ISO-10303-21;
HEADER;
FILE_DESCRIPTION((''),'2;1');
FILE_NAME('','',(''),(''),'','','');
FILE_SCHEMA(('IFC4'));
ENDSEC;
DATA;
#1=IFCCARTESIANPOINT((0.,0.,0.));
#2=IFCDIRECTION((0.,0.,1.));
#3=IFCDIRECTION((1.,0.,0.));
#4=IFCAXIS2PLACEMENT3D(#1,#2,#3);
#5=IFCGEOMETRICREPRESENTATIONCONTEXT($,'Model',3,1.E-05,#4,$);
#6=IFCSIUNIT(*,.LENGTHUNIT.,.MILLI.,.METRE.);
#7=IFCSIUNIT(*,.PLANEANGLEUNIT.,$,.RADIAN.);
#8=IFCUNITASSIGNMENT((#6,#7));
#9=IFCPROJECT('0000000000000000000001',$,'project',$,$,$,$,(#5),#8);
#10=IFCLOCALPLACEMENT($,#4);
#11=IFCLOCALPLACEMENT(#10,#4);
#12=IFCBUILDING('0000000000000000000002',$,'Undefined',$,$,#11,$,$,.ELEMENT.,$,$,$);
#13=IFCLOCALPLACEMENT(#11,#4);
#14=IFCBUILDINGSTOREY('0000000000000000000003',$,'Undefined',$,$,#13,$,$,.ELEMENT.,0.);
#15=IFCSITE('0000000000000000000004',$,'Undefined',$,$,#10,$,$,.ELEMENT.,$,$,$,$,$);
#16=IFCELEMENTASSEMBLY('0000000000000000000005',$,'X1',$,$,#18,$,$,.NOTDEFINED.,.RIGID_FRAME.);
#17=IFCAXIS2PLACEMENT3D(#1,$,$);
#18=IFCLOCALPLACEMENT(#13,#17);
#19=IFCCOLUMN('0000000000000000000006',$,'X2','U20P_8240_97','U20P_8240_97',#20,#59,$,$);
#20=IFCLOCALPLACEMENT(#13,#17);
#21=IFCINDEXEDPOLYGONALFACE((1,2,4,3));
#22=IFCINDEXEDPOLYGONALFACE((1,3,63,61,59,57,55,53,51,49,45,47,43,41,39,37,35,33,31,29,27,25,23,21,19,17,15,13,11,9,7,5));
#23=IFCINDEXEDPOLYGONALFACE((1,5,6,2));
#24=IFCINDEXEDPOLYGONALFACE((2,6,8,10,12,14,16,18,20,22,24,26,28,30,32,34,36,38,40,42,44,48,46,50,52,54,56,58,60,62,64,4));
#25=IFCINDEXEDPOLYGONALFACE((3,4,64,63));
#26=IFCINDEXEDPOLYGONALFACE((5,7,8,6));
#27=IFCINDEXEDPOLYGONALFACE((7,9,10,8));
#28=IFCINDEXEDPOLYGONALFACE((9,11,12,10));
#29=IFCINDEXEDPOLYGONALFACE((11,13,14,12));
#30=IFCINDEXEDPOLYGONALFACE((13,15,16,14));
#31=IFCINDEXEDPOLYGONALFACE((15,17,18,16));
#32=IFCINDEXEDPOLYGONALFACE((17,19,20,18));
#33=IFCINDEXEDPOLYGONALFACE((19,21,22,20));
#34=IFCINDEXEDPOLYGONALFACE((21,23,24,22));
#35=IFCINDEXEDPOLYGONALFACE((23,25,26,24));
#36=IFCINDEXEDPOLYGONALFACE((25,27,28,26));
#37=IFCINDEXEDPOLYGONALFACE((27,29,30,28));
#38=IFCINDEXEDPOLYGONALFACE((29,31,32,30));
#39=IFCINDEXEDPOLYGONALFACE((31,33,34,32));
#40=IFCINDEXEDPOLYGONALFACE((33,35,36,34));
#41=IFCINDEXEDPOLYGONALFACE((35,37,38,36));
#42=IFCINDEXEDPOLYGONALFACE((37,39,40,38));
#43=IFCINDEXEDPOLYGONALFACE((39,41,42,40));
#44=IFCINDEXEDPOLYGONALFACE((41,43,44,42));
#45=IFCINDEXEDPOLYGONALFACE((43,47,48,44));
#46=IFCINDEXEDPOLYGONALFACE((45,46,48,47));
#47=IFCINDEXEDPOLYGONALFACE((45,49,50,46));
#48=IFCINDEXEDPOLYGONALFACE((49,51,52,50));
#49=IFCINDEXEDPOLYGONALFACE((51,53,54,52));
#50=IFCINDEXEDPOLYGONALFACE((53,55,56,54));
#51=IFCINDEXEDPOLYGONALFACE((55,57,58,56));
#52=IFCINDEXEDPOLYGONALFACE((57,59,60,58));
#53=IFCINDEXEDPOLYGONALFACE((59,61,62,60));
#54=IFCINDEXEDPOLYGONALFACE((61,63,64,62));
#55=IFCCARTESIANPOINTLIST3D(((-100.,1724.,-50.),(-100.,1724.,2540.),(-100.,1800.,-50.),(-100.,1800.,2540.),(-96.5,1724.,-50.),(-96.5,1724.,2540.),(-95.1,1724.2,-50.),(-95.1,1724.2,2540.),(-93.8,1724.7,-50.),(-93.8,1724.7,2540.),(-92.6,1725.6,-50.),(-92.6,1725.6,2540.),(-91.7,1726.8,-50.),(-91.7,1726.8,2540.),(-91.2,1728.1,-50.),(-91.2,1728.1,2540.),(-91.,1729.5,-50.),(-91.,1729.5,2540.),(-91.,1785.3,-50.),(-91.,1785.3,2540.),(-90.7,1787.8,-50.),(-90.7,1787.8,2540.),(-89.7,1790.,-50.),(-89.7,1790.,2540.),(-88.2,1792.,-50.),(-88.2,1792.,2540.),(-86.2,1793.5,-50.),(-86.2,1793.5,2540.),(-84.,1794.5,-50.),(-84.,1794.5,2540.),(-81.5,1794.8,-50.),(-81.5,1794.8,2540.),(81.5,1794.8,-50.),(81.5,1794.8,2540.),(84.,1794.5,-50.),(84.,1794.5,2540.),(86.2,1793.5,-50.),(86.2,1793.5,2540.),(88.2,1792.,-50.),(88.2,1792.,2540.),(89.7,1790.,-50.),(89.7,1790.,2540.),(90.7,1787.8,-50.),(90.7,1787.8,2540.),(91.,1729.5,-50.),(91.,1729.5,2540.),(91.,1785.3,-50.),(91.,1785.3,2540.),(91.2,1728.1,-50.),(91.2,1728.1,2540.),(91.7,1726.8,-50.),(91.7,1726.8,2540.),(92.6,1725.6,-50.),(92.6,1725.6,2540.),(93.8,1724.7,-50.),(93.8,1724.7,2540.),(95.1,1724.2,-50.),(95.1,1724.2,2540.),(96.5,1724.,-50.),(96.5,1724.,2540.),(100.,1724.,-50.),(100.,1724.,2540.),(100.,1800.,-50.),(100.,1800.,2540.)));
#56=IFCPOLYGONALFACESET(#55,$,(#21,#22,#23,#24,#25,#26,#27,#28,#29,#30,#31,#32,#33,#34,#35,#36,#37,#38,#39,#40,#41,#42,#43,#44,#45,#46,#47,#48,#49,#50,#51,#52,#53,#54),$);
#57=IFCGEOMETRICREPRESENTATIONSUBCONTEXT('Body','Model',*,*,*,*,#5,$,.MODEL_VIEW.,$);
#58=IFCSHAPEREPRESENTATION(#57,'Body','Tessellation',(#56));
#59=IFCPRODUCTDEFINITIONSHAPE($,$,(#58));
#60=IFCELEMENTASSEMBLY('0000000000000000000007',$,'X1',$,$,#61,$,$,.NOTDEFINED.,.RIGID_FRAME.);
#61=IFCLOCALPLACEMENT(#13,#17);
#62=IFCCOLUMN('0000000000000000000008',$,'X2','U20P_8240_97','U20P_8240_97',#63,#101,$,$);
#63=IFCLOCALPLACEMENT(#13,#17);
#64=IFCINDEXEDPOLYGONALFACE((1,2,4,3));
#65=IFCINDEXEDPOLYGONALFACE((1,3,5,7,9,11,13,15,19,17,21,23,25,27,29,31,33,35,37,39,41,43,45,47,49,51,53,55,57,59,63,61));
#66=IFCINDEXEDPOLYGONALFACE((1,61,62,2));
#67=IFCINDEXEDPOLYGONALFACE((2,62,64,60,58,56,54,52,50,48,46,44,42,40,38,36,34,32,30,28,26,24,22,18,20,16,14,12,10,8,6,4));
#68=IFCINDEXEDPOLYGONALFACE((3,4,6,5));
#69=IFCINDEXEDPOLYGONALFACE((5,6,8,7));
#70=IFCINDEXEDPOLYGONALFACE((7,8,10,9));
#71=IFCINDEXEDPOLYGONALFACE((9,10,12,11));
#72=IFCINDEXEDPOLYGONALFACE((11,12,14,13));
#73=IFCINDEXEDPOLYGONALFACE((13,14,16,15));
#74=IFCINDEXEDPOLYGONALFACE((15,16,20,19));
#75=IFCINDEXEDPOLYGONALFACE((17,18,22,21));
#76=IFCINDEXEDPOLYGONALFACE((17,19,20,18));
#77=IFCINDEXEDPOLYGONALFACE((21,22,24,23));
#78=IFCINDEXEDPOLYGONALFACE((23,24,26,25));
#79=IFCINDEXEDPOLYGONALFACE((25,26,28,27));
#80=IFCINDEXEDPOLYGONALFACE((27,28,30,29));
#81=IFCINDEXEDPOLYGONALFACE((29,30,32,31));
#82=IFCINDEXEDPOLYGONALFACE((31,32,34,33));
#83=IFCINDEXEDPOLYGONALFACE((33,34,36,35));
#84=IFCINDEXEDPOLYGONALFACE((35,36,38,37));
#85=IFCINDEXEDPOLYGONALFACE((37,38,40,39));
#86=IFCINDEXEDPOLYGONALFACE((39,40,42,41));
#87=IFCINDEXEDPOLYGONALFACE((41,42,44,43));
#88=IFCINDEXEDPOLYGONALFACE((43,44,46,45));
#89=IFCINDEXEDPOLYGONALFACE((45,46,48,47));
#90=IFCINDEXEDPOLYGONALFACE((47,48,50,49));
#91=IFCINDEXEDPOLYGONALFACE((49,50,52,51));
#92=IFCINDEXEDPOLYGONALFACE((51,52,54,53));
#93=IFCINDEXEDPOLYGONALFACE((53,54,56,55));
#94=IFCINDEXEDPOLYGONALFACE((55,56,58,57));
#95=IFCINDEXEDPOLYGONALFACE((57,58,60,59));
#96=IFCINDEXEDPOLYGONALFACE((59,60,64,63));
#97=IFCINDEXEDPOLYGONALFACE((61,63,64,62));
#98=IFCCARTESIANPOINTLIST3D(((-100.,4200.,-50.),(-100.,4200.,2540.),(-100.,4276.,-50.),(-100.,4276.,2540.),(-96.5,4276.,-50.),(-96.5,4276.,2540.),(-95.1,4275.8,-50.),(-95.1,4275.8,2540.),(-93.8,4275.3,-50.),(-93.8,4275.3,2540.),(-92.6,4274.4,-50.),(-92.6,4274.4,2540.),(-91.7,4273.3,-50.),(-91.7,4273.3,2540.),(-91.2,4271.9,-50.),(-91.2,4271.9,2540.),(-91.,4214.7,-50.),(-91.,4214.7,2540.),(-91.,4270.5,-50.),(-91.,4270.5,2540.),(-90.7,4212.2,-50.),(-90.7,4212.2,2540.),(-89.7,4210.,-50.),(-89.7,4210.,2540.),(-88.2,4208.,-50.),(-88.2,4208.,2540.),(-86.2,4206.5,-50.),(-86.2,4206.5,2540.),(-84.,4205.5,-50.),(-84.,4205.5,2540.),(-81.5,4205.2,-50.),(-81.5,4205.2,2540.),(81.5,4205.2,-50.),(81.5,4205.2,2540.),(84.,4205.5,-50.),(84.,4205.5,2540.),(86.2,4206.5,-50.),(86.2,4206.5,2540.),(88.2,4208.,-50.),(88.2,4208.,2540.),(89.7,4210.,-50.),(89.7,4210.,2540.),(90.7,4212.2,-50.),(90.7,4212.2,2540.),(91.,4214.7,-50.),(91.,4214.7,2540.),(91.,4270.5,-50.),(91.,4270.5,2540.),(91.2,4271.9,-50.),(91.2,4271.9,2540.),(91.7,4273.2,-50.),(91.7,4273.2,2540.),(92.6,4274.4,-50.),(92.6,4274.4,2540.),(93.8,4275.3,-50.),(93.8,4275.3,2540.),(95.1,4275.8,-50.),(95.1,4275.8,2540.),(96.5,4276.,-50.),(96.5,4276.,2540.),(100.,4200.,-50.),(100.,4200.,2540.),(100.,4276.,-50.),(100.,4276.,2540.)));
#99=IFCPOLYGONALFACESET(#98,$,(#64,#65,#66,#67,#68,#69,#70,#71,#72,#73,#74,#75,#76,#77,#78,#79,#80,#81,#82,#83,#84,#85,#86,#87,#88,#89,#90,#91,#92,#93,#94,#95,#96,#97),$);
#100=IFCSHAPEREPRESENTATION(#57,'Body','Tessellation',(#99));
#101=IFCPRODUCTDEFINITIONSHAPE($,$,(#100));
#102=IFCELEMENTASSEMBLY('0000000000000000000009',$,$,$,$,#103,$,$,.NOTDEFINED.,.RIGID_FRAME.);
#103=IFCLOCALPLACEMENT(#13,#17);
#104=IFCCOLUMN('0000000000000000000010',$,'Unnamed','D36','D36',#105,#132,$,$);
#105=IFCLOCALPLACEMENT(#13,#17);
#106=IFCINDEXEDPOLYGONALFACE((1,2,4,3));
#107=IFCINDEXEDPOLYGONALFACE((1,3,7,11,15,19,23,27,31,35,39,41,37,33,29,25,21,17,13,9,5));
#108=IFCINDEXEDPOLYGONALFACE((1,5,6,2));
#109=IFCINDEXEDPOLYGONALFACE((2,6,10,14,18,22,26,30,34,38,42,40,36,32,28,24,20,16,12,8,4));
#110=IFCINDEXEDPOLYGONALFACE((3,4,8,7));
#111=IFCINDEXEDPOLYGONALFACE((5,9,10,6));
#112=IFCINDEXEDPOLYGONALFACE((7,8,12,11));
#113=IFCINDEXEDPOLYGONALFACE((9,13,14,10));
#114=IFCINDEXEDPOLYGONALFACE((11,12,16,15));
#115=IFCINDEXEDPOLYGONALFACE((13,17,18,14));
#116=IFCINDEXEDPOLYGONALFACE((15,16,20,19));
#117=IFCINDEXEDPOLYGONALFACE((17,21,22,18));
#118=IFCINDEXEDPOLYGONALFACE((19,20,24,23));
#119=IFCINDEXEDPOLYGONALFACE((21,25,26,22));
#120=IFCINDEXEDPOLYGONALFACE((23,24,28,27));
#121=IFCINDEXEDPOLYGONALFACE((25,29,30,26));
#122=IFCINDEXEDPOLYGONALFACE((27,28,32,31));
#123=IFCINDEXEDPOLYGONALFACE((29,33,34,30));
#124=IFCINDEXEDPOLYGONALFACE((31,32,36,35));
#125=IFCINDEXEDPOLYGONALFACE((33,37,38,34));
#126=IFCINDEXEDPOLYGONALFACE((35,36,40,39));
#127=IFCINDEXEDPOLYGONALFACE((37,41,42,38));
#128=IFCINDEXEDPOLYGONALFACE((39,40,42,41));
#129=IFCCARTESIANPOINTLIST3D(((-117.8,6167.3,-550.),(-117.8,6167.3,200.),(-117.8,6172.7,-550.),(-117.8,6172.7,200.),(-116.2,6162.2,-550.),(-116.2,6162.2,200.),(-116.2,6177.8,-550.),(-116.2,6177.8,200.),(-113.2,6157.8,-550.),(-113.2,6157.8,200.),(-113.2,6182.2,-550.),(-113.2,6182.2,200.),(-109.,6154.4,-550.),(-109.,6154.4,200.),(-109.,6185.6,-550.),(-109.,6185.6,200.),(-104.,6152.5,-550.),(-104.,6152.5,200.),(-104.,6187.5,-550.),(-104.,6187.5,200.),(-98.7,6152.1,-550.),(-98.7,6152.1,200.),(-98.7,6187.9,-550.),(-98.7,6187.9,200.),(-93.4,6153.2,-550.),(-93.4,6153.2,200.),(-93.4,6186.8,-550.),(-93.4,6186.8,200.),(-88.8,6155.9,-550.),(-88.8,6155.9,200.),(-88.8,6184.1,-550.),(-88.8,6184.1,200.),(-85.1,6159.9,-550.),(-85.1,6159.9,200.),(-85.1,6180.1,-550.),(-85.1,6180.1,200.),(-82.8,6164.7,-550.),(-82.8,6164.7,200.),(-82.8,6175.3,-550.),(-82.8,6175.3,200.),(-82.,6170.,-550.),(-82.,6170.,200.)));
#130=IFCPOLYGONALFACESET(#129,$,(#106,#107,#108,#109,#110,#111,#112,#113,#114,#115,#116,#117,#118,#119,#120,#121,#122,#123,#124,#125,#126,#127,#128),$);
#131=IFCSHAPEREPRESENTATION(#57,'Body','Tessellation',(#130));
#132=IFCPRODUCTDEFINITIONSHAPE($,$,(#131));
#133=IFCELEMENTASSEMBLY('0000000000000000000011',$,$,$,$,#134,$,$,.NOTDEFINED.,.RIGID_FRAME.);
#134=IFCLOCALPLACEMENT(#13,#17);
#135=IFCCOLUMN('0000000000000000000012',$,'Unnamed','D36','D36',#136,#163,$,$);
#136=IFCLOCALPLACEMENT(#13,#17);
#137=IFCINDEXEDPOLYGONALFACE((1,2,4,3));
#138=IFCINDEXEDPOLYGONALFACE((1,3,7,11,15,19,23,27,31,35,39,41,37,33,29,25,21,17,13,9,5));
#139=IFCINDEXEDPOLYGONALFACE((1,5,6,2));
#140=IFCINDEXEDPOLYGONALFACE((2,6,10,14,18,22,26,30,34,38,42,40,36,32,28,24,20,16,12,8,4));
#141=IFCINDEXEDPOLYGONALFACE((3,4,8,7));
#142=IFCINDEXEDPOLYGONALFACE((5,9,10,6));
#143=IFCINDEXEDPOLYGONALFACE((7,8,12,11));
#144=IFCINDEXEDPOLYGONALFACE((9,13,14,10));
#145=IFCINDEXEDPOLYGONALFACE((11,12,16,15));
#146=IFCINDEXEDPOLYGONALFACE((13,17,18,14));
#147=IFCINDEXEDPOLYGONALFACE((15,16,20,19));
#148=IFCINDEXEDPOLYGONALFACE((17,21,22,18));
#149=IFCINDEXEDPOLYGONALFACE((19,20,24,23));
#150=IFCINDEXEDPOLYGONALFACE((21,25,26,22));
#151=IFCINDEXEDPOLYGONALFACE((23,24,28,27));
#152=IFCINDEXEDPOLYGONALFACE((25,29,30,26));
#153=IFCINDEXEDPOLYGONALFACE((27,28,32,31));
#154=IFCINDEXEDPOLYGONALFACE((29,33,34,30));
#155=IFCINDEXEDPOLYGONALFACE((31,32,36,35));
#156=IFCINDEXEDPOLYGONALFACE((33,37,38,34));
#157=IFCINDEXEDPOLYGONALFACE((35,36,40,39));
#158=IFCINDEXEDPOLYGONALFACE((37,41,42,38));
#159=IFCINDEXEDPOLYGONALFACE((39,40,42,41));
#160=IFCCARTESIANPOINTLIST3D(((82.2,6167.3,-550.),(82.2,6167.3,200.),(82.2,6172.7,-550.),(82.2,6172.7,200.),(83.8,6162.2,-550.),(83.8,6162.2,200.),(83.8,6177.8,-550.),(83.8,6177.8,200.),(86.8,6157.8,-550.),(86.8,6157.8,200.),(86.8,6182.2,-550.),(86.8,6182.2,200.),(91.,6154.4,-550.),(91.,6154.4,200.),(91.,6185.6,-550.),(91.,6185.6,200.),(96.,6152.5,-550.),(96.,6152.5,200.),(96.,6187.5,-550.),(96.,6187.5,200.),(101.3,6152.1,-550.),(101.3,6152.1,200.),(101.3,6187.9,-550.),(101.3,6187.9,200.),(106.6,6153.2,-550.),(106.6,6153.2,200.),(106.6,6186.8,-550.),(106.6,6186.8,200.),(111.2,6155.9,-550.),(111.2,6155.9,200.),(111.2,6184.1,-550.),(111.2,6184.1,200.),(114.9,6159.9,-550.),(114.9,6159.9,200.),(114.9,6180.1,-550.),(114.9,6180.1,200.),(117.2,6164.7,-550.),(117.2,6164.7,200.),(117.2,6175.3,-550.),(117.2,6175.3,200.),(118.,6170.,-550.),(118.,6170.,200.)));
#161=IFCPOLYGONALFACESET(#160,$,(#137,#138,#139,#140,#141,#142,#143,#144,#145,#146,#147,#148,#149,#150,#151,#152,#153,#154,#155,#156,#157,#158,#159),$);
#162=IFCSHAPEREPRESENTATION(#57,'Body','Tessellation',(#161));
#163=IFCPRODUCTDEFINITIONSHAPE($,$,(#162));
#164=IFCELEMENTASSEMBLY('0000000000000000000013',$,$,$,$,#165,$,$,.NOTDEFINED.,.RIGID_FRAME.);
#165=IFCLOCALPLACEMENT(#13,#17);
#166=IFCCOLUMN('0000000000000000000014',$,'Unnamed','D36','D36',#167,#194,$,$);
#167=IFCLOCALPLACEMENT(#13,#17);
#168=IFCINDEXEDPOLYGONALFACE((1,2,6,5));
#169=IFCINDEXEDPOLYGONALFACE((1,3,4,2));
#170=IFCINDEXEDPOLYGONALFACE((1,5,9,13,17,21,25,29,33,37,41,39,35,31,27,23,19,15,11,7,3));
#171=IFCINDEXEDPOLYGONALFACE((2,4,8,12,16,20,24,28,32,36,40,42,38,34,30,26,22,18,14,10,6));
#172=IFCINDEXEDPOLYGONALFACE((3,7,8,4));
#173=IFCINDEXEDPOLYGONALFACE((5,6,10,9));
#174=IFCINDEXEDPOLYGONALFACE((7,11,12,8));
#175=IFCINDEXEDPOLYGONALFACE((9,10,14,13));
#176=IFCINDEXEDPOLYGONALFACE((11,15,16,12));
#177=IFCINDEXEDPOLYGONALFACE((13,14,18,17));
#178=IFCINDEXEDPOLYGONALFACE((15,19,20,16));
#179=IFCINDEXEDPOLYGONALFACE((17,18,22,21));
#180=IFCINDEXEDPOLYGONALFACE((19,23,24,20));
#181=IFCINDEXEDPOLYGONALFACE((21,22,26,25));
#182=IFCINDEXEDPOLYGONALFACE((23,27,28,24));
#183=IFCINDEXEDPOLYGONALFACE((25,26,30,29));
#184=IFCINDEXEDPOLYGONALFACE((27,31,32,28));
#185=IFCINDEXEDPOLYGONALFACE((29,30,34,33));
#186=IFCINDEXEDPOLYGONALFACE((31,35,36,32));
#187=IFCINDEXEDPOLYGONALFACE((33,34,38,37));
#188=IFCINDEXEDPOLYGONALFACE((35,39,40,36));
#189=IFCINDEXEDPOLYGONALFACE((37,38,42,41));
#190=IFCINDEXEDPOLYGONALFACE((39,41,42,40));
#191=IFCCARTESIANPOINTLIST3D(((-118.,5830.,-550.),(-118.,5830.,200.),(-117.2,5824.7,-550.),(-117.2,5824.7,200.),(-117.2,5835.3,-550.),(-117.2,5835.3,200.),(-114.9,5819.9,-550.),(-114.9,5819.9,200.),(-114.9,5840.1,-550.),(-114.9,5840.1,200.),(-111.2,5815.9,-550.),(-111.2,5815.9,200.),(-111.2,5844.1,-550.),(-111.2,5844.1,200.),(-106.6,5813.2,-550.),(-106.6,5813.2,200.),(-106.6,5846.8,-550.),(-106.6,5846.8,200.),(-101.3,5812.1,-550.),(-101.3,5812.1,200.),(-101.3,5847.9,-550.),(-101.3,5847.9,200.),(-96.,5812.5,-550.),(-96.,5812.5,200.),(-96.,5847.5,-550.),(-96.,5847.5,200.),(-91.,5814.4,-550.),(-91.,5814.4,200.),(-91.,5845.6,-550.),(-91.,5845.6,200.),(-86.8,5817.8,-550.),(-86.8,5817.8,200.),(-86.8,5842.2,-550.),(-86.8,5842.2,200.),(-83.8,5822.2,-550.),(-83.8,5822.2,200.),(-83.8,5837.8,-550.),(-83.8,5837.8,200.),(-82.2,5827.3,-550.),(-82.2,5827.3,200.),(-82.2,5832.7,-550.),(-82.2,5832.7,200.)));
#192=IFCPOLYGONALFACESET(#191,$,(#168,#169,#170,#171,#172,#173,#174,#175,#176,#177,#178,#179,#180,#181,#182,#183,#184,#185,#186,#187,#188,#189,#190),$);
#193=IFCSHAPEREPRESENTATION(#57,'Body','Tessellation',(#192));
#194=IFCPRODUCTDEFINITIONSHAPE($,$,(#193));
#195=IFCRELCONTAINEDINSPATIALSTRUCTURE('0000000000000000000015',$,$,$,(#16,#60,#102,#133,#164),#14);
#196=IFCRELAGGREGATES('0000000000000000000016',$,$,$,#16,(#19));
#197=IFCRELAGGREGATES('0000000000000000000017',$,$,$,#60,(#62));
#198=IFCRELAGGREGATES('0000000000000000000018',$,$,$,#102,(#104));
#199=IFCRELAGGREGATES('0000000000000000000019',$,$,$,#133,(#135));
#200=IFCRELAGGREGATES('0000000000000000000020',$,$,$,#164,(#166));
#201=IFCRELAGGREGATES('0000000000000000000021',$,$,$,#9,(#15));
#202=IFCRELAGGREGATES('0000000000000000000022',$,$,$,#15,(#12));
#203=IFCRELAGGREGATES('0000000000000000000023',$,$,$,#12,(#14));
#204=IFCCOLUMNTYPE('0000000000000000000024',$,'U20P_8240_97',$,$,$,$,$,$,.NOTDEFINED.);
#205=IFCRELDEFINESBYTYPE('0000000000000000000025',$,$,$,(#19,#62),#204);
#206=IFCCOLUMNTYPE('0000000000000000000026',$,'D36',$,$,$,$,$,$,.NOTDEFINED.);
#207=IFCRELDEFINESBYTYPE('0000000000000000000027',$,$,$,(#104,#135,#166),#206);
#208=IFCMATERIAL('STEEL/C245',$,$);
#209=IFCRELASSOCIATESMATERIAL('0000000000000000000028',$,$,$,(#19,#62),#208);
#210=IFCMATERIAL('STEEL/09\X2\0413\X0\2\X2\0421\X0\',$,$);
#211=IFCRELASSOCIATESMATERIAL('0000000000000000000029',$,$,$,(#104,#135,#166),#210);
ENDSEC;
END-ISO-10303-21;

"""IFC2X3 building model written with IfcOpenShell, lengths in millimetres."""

from ifc_helpers import new_model, si_unit, frame, origin_with_axes, origin_2d_with_axis, place, context, subcontext, project, spatial, circle, u_section, extrude, material, type_object, element, aggregate, save


model = new_model("IFC2X3")

# Units and contexts
model_context = context("Model", 3, precision=1e-05, world=origin_with_axes())
body_context = subcontext(model_context, "Body", "Model", "MODEL_VIEW")
ifc_project = project(units=[si_unit("LENGTHUNIT", "METRE", prefix="MILLI"), si_unit("PLANEANGLEUNIT", "RADIAN")], contexts=[model_context])

# Site, building, storey
site_placement = place(None, origin_with_axes())
site = spatial("IfcSite", under=ifc_project, at=site_placement, Name="Undefined", CompositionType="ELEMENT")
building_placement = place(site_placement, origin_with_axes())
building = spatial("IfcBuilding", under=site, at=building_placement, Name="Undefined", CompositionType="ELEMENT")
storey_placement = place(building_placement, origin_with_axes())
storey = spatial("IfcBuildingStorey", under=building, at=storey_placement, Name="Undefined", CompositionType="ELEMENT", Elevation=0.0)

# Element assemblies, columns
assembly_1_placement = place(storey_placement, origin_with_axes())
assembly_1 = element("IfcElementAssembly", 1, at=assembly_1_placement, inside=storey, Name="X1", AssemblyPlace="NOTDEFINED", PredefinedType="RIGID_FRAME")
ifc_material_1 = material(Name="STEEL/C245")
column_type_1 = type_object("IfcColumnType", Name="U20P_8240_97", PredefinedType="NOTDEFINED")
column_1_placement = place(assembly_1_placement, frame((0.0, 1762.0, -50.0), z_axis=(0.0, 0.0, 1.0), x_axis=(-1.0, 0.0, 0.0)))
column_1 = element("IfcColumn", 2, at=column_1_placement, type_object=column_type_1, material=ifc_material_1, Name="X2", Description="U20P_8240_97", ObjectType="U20P_8240_97", context=body_context, shape_type="SweptSolid", body=[
    extrude(u_section(Depth=200.0, FlangeWidth=76.0, WebThickness=5.2, FlangeThickness=9.0, FilletRadius=9.5, EdgeRadius=5.5, at=origin_2d_with_axis()), frame((0.0, 0.0, 2590.0), z_axis=(0.0, 0.0, -1.0), x_axis=(0.0, 1.0, 0.0)), (0.0, 0.0, 1.0), 2590.0),
])
aggregate(assembly_1, [column_1])
assembly_2_placement = place(storey_placement, origin_with_axes())
assembly_2 = element("IfcElementAssembly", 3, at=assembly_2_placement, inside=storey, Name="X1", AssemblyPlace="NOTDEFINED", PredefinedType="RIGID_FRAME")
column_2_placement = place(assembly_2_placement, frame((0.0, 4238.0, -50.0), z_axis=(0.0, 0.0, 1.0), x_axis=(1.0, 0.0, 0.0)))
column_2 = element("IfcColumn", 4, at=column_2_placement, type_object=column_type_1, material=ifc_material_1, Name="X2", Description="U20P_8240_97", ObjectType="U20P_8240_97", context=body_context, shape_type="SweptSolid", body=[
    extrude(u_section(Depth=200.0, FlangeWidth=76.0, WebThickness=5.2, FlangeThickness=9.0, FilletRadius=9.5, EdgeRadius=5.5, at=origin_2d_with_axis()), frame((0.0, 0.0, 2590.0), z_axis=(0.0, 0.0, -1.0), x_axis=(0.0, 1.0, 0.0)), (0.0, 0.0, 1.0), 2590.0),
])
aggregate(assembly_2, [column_2])
assembly_3_placement = place(storey_placement, origin_with_axes())
assembly_3 = element("IfcElementAssembly", 5, at=assembly_3_placement, inside=storey, AssemblyPlace="NOTDEFINED", PredefinedType="RIGID_FRAME")
ifc_material_2 = material(Name="STEEL/09Г2С")
column_type_2 = type_object("IfcColumnType", Name="D36", PredefinedType="NOTDEFINED")
column_3_placement = place(assembly_3_placement, frame((-100.0, 6170.0, -550.0), z_axis=(0.0, 0.0, 1.0), x_axis=(0.0, -1.0, 0.0)))
column_3 = element("IfcColumn", 6, at=column_3_placement, type_object=column_type_2, material=ifc_material_2, Name="Unnamed", Description="D36", ObjectType="D36", context=body_context, shape_type="SweptSolid", body=[
    extrude(circle(Radius=18.0, at=origin_2d_with_axis()), frame((0.0, 0.0, 750.0), z_axis=(0.0, 0.0, -1.0), x_axis=(0.0, 1.0, 0.0)), (0.0, 0.0, 1.0), 750.0),
])
aggregate(assembly_3, [column_3])
assembly_4_placement = place(storey_placement, origin_with_axes())
assembly_4 = element("IfcElementAssembly", 7, at=assembly_4_placement, inside=storey, AssemblyPlace="NOTDEFINED", PredefinedType="RIGID_FRAME")
column_4_placement = place(assembly_4_placement, frame((100.0, 6170.0, -550.0), z_axis=(0.0, 0.0, 1.0), x_axis=(0.0, -1.0, 0.0)))
column_4 = element("IfcColumn", 8, at=column_4_placement, type_object=column_type_2, material=ifc_material_2, Name="Unnamed", Description="D36", ObjectType="D36", context=body_context, shape_type="SweptSolid", body=[
    extrude(circle(Radius=18.0, at=origin_2d_with_axis()), frame((0.0, 0.0, 750.0), z_axis=(0.0, 0.0, -1.0), x_axis=(0.0, 1.0, 0.0)), (0.0, 0.0, 1.0), 750.0),
])
aggregate(assembly_4, [column_4])
assembly_5_placement = place(storey_placement, origin_with_axes())
assembly_5 = element("IfcElementAssembly", 9, at=assembly_5_placement, inside=storey, AssemblyPlace="NOTDEFINED", PredefinedType="RIGID_FRAME")
column_5_placement = place(assembly_5_placement, frame((-100.0, 5830.0, -550.0), z_axis=(0.0, 0.0, 1.0), x_axis=(0.0, 1.0, 0.0)))
column_5 = element("IfcColumn", 10, at=column_5_placement, type_object=column_type_2, material=ifc_material_2, Name="Unnamed", Description="D36", ObjectType="D36", context=body_context, shape_type="SweptSolid", body=[
    extrude(circle(Radius=18.0, at=origin_2d_with_axis()), frame((0.0, 0.0, 750.0), z_axis=(0.0, 0.0, -1.0), x_axis=(0.0, 1.0, 0.0)), (0.0, 0.0, 1.0), 750.0),
])
aggregate(assembly_5, [column_5])

save(model, "model.ifc")
